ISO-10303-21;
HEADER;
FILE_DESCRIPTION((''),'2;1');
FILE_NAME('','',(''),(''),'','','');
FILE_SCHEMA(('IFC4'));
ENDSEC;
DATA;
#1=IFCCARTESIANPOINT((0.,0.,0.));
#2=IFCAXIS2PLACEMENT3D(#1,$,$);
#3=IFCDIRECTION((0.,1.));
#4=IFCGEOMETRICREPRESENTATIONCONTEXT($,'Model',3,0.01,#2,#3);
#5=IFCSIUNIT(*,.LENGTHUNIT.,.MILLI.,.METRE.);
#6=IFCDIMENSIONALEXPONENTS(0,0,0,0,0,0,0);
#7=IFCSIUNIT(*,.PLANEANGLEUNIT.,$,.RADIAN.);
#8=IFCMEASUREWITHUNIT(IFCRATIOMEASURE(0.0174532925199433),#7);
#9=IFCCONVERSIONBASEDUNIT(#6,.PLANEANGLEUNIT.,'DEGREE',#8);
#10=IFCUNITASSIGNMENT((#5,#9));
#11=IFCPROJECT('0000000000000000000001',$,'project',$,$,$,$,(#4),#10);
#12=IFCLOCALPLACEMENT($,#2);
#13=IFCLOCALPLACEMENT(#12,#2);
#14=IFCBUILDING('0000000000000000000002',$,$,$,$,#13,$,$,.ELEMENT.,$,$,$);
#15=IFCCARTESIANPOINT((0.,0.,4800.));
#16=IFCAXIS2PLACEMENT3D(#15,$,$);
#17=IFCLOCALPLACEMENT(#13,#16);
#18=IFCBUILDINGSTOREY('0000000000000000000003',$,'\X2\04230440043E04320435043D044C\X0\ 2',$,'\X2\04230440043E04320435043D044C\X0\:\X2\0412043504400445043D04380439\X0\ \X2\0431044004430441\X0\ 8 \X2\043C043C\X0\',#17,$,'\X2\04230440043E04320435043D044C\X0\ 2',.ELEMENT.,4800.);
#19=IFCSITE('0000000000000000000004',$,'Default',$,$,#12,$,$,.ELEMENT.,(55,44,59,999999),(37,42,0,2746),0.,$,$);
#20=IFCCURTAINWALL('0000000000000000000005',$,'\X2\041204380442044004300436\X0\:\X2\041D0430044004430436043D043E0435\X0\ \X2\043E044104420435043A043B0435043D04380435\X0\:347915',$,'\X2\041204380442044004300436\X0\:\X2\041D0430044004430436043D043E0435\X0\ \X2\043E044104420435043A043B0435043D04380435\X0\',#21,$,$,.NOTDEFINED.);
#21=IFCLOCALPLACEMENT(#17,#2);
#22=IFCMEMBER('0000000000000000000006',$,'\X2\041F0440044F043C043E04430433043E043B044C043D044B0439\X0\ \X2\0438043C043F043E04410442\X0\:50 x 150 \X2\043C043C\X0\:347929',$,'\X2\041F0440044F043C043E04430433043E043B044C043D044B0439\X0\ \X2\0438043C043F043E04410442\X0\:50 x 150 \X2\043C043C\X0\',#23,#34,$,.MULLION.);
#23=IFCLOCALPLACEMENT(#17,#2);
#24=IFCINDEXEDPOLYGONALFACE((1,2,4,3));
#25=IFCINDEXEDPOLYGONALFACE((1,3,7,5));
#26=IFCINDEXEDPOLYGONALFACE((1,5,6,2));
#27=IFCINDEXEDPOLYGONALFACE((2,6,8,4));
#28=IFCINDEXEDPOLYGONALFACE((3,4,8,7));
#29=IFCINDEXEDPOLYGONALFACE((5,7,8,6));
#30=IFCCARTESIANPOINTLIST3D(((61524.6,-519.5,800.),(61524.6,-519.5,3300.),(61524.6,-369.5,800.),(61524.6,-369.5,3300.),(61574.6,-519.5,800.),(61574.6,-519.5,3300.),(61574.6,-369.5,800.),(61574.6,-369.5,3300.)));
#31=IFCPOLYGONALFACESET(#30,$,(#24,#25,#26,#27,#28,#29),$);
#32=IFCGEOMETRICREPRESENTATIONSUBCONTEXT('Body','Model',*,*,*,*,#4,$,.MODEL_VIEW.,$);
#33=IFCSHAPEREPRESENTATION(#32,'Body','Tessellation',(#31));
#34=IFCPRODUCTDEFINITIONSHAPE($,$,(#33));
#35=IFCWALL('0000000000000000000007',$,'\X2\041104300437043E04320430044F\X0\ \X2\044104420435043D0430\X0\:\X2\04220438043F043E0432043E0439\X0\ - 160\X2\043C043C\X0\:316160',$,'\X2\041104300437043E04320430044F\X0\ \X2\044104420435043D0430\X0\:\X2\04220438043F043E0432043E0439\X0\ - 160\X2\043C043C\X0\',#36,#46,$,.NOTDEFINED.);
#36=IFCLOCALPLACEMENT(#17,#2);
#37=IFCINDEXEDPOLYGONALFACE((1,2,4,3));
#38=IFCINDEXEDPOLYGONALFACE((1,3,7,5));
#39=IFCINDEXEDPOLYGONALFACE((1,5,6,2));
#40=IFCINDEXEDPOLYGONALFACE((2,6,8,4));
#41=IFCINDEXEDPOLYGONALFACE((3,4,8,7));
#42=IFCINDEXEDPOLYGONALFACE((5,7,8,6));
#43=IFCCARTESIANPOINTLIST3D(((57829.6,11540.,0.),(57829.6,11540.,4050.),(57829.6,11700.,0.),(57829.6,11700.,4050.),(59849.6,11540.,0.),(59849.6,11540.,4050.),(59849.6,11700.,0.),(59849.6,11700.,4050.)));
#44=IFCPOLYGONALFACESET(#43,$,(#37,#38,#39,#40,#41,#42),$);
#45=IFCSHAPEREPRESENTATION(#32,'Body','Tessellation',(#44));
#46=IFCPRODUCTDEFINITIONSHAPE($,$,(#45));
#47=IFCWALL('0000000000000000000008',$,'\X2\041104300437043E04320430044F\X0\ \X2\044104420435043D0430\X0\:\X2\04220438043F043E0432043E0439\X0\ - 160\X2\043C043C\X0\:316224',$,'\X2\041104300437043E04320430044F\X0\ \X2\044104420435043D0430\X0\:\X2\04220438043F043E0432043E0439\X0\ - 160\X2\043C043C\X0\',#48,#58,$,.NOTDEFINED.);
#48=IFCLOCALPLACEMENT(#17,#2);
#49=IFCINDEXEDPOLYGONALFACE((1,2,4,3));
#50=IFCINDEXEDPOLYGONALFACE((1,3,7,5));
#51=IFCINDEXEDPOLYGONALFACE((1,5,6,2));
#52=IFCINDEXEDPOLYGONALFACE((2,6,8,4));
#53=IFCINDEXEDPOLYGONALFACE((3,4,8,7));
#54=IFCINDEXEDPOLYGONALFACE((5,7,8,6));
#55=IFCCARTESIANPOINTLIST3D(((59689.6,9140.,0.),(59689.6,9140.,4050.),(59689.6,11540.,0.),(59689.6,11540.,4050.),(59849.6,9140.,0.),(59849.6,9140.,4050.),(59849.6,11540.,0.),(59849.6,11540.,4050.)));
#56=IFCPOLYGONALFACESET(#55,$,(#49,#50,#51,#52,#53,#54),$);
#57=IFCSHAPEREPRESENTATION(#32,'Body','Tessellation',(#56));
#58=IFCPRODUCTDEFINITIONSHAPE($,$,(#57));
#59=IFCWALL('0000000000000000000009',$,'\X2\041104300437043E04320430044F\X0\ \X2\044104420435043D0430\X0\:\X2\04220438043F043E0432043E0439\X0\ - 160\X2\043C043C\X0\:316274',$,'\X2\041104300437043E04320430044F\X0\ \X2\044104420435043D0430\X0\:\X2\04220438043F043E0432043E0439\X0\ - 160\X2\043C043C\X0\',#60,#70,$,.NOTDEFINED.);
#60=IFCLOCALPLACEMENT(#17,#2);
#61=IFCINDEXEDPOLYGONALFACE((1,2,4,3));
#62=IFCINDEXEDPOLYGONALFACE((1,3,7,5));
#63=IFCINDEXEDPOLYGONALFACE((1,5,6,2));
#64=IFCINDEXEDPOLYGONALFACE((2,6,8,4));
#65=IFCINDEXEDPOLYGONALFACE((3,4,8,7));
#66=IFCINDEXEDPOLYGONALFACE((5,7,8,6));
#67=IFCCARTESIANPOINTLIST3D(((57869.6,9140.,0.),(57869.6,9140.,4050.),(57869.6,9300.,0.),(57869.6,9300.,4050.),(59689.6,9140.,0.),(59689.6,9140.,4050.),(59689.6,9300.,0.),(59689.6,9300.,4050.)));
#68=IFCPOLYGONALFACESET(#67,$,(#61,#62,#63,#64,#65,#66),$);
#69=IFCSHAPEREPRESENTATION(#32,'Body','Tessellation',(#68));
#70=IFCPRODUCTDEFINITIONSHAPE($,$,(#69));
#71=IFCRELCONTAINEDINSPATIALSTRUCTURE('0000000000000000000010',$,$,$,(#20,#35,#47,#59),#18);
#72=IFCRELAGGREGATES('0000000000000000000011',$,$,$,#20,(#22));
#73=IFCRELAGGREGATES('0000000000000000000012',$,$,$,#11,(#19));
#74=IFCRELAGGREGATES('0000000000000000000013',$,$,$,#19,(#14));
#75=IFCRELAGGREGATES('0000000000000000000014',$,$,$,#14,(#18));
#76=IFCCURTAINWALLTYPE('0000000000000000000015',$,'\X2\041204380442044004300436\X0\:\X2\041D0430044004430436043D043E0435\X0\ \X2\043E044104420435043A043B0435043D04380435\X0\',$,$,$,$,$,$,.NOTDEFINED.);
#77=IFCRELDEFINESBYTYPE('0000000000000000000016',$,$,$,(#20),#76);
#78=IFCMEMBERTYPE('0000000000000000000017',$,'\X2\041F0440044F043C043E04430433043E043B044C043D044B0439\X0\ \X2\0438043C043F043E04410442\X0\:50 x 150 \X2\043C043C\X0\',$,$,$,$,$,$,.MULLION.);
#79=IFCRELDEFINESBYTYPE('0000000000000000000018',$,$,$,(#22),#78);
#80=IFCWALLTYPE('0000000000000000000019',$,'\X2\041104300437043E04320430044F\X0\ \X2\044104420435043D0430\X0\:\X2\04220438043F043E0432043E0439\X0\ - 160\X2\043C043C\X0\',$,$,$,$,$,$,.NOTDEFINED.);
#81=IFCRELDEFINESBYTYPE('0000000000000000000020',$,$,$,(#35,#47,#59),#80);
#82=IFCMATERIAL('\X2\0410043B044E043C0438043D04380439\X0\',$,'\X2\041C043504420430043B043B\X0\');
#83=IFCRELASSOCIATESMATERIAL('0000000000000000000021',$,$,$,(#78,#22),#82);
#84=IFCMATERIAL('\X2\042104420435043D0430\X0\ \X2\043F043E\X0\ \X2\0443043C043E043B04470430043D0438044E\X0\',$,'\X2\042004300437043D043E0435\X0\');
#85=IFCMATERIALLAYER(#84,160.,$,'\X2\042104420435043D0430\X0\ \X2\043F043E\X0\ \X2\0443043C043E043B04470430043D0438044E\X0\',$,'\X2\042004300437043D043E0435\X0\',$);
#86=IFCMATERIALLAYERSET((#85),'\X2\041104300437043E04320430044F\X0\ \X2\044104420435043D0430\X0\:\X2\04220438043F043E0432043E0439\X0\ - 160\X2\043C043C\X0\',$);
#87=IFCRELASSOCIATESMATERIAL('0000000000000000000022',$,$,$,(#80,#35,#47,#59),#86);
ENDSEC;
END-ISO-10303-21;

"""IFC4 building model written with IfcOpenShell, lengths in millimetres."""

from ifc_helpers import new_model, entity, si_unit, converted_unit, direction, frame, frame_2d, origin, origin_2d_with_axis, place, context, subcontext, project, spatial, rectangle, extrude, source, transform, mapped, material, layer, layer_set, layer_usage, material_profile, profile_set, profile_usage, type_object, type_shapes, element, aggregate, save


model = new_model("IFC4")

# Units and contexts
model_context = context("Model", 3, precision=0.01, world=origin(), true_north=direction((0.0, 1.0)))
body_context = subcontext(model_context, "Body", "Model", "MODEL_VIEW")
ifc_project = project(units=[si_unit("LENGTHUNIT", "METRE", prefix="MILLI"), converted_unit("PLANEANGLEUNIT", "DEGREE", entity("IfcRatioMeasure", 0.0174532925199433), si_unit("PLANEANGLEUNIT", "RADIAN"), dimensions=[0, 0, 0, 0, 0, 0, 0])], contexts=[model_context])

# Site, building, storey
site_placement = place(None, origin())
site = spatial("IfcSite", under=ifc_project, at=site_placement, Name="Default", CompositionType="ELEMENT", RefLatitude=(55, 44, 59, 999999), RefLongitude=(37, 42, 0, 2746), RefElevation=0.0)
building_placement = place(site_placement, origin())
building = spatial("IfcBuilding", under=site, at=building_placement, CompositionType="ELEMENT")
storey_placement = place(building_placement, frame((0.0, 0.0, 4800.0)))
storey = spatial("IfcBuildingStorey", under=building, at=storey_placement, Name="Уровень 2", ObjectType="Уровень:Верхний брус 8 мм", LongName="Уровень 2", CompositionType="ELEMENT", Elevation=4800.0)

# Curtain wall
curtain_wall_type = type_object("IfcCurtainWallType", Name="Витраж:Наружное остекление", PredefinedType="NOTDEFINED")
ifc_material_1 = material(Name="Алюминий", Category="Металл")
ifc_material_profile = material_profile(ifc_material_1, rectangle(XDim=150.0, YDim=50.0, at=origin_2d_with_axis()), Name="50 x 150 мм")
ifc_profile_set = profile_set([ifc_material_profile], Name="50 x 150 мм")
curtain_wall_1_placement = place(storey_placement, frame((0.0, 0.0, -4800.0)))
curtain_wall_1 = element("IfcCurtainWall", 1, at=curtain_wall_1_placement, inside=storey, type_object=curtain_wall_type, Name="Витраж:Наружное остекление:347915", ObjectType="Витраж:Наружное остекление", PredefinedType="NOTDEFINED")

# Member
member_type_1 = type_object("IfcMemberType", Name="Прямоугольный импост:50 x 150 мм", PredefinedType="MULLION", material=ifc_profile_set)
shared_shape_1 = source(origin(), body_context, "Body", "SweptSolid", [
    extrude(rectangle(XDim=150.0, YDim=50.0, at=origin_2d_with_axis()), frame((0.0, 0.0, -2500.0), z_axis=(0.0, 0.0, 1.0), x_axis=(0.0, -1.0, 0.0)), (0.0, 0.0, 1.0), 2500.0),
])
type_shapes(member_type_1, [shared_shape_1])
ifc_profile_usage_1 = profile_usage(ifc_profile_set)
member_1_placement = place(storey_placement, frame((61549.6, -444.5, 800.0), z_axis=(0.0, 0.0, -1.0), x_axis=(1.0, 0.0, 0.0)))
member_1 = element("IfcMember", 2, at=member_1_placement, type_object=member_type_1, material=ifc_profile_usage_1, Name="Прямоугольный импост:50 x 150 мм:347929", ObjectType="Прямоугольный импост:50 x 150 мм", PredefinedType="MULLION", context=body_context, shape_type="MappedRepresentation", body=[
    mapped(shared_shape_1, transform((0.0, 0.0, 0.0), scale=1.0)),
])

aggregate(curtain_wall_1, [member_1])

# Walls
ifc_material_2 = material(Name="Стена по умолчанию", Category="Разное")
ifc_layer = layer(ifc_material_2, 160.0, Name="Стена по умолчанию", Category="Разное")
ifc_layer_set = layer_set([ifc_layer], Name="Базовая стена:Типовой - 160мм")
ifc_layer_usage_1 = layer_usage(ifc_layer_set, "AXIS2", "NEGATIVE", 80.0)
wall_type = type_object("IfcWallType", Name="Базовая стена:Типовой - 160мм", PredefinedType="NOTDEFINED", material=ifc_layer_set)
wall_1_placement = place(storey_placement, frame((57829.6, 11620.0, 0.0)))
element("IfcWall", 3, at=wall_1_placement, inside=storey, type_object=wall_type, material=ifc_layer_usage_1, Name="Базовая стена:Типовой - 160мм:316160", ObjectType="Базовая стена:Типовой - 160мм", PredefinedType="NOTDEFINED", context=body_context, shape_type="SweptSolid", body=[
    extrude(rectangle(XDim=2020.0, YDim=160.0, at=frame_2d((1010.0, 0.0), x_axis=(-1.0, 0.0))), origin(), (0.0, 0.0, 1.0), 4050.0),
])
ifc_layer_usage_2 = layer_usage(ifc_layer_set, "AXIS2", "NEGATIVE", 80.0)
wall_2_placement = place(storey_placement, frame((59769.6, 11540.0, 0.0), z_axis=(0.0, 0.0, 1.0), x_axis=(0.0, -1.0, 0.0)))
element("IfcWall", 4, at=wall_2_placement, inside=storey, type_object=wall_type, material=ifc_layer_usage_2, Name="Базовая стена:Типовой - 160мм:316224", ObjectType="Базовая стена:Типовой - 160мм", PredefinedType="NOTDEFINED", context=body_context, shape_type="SweptSolid", body=[
    extrude(rectangle(XDim=2400.0, YDim=160.0, at=frame_2d((1200.0, 0.0), x_axis=(-1.0, 0.0))), origin(), (0.0, 0.0, 1.0), 4050.0),
])
ifc_layer_usage_3 = layer_usage(ifc_layer_set, "AXIS2", "NEGATIVE", 80.0)
wall_3_placement = place(storey_placement, frame((59689.6, 9220.0, 0.0), z_axis=(0.0, 0.0, 1.0), x_axis=(-1.0, 0.0, 0.0)))
element("IfcWall", 5, at=wall_3_placement, inside=storey, type_object=wall_type, material=ifc_layer_usage_3, Name="Базовая стена:Типовой - 160мм:316274", ObjectType="Базовая стена:Типовой - 160мм", PredefinedType="NOTDEFINED", context=body_context, shape_type="SweptSolid", body=[
    extrude(rectangle(XDim=1820.0, YDim=160.0, at=frame_2d((910.0, 0.0), x_axis=(-1.0, 0.0))), origin(), (0.0, 0.0, 1.0), 4050.0),
])

save(model, "model.ifc")
